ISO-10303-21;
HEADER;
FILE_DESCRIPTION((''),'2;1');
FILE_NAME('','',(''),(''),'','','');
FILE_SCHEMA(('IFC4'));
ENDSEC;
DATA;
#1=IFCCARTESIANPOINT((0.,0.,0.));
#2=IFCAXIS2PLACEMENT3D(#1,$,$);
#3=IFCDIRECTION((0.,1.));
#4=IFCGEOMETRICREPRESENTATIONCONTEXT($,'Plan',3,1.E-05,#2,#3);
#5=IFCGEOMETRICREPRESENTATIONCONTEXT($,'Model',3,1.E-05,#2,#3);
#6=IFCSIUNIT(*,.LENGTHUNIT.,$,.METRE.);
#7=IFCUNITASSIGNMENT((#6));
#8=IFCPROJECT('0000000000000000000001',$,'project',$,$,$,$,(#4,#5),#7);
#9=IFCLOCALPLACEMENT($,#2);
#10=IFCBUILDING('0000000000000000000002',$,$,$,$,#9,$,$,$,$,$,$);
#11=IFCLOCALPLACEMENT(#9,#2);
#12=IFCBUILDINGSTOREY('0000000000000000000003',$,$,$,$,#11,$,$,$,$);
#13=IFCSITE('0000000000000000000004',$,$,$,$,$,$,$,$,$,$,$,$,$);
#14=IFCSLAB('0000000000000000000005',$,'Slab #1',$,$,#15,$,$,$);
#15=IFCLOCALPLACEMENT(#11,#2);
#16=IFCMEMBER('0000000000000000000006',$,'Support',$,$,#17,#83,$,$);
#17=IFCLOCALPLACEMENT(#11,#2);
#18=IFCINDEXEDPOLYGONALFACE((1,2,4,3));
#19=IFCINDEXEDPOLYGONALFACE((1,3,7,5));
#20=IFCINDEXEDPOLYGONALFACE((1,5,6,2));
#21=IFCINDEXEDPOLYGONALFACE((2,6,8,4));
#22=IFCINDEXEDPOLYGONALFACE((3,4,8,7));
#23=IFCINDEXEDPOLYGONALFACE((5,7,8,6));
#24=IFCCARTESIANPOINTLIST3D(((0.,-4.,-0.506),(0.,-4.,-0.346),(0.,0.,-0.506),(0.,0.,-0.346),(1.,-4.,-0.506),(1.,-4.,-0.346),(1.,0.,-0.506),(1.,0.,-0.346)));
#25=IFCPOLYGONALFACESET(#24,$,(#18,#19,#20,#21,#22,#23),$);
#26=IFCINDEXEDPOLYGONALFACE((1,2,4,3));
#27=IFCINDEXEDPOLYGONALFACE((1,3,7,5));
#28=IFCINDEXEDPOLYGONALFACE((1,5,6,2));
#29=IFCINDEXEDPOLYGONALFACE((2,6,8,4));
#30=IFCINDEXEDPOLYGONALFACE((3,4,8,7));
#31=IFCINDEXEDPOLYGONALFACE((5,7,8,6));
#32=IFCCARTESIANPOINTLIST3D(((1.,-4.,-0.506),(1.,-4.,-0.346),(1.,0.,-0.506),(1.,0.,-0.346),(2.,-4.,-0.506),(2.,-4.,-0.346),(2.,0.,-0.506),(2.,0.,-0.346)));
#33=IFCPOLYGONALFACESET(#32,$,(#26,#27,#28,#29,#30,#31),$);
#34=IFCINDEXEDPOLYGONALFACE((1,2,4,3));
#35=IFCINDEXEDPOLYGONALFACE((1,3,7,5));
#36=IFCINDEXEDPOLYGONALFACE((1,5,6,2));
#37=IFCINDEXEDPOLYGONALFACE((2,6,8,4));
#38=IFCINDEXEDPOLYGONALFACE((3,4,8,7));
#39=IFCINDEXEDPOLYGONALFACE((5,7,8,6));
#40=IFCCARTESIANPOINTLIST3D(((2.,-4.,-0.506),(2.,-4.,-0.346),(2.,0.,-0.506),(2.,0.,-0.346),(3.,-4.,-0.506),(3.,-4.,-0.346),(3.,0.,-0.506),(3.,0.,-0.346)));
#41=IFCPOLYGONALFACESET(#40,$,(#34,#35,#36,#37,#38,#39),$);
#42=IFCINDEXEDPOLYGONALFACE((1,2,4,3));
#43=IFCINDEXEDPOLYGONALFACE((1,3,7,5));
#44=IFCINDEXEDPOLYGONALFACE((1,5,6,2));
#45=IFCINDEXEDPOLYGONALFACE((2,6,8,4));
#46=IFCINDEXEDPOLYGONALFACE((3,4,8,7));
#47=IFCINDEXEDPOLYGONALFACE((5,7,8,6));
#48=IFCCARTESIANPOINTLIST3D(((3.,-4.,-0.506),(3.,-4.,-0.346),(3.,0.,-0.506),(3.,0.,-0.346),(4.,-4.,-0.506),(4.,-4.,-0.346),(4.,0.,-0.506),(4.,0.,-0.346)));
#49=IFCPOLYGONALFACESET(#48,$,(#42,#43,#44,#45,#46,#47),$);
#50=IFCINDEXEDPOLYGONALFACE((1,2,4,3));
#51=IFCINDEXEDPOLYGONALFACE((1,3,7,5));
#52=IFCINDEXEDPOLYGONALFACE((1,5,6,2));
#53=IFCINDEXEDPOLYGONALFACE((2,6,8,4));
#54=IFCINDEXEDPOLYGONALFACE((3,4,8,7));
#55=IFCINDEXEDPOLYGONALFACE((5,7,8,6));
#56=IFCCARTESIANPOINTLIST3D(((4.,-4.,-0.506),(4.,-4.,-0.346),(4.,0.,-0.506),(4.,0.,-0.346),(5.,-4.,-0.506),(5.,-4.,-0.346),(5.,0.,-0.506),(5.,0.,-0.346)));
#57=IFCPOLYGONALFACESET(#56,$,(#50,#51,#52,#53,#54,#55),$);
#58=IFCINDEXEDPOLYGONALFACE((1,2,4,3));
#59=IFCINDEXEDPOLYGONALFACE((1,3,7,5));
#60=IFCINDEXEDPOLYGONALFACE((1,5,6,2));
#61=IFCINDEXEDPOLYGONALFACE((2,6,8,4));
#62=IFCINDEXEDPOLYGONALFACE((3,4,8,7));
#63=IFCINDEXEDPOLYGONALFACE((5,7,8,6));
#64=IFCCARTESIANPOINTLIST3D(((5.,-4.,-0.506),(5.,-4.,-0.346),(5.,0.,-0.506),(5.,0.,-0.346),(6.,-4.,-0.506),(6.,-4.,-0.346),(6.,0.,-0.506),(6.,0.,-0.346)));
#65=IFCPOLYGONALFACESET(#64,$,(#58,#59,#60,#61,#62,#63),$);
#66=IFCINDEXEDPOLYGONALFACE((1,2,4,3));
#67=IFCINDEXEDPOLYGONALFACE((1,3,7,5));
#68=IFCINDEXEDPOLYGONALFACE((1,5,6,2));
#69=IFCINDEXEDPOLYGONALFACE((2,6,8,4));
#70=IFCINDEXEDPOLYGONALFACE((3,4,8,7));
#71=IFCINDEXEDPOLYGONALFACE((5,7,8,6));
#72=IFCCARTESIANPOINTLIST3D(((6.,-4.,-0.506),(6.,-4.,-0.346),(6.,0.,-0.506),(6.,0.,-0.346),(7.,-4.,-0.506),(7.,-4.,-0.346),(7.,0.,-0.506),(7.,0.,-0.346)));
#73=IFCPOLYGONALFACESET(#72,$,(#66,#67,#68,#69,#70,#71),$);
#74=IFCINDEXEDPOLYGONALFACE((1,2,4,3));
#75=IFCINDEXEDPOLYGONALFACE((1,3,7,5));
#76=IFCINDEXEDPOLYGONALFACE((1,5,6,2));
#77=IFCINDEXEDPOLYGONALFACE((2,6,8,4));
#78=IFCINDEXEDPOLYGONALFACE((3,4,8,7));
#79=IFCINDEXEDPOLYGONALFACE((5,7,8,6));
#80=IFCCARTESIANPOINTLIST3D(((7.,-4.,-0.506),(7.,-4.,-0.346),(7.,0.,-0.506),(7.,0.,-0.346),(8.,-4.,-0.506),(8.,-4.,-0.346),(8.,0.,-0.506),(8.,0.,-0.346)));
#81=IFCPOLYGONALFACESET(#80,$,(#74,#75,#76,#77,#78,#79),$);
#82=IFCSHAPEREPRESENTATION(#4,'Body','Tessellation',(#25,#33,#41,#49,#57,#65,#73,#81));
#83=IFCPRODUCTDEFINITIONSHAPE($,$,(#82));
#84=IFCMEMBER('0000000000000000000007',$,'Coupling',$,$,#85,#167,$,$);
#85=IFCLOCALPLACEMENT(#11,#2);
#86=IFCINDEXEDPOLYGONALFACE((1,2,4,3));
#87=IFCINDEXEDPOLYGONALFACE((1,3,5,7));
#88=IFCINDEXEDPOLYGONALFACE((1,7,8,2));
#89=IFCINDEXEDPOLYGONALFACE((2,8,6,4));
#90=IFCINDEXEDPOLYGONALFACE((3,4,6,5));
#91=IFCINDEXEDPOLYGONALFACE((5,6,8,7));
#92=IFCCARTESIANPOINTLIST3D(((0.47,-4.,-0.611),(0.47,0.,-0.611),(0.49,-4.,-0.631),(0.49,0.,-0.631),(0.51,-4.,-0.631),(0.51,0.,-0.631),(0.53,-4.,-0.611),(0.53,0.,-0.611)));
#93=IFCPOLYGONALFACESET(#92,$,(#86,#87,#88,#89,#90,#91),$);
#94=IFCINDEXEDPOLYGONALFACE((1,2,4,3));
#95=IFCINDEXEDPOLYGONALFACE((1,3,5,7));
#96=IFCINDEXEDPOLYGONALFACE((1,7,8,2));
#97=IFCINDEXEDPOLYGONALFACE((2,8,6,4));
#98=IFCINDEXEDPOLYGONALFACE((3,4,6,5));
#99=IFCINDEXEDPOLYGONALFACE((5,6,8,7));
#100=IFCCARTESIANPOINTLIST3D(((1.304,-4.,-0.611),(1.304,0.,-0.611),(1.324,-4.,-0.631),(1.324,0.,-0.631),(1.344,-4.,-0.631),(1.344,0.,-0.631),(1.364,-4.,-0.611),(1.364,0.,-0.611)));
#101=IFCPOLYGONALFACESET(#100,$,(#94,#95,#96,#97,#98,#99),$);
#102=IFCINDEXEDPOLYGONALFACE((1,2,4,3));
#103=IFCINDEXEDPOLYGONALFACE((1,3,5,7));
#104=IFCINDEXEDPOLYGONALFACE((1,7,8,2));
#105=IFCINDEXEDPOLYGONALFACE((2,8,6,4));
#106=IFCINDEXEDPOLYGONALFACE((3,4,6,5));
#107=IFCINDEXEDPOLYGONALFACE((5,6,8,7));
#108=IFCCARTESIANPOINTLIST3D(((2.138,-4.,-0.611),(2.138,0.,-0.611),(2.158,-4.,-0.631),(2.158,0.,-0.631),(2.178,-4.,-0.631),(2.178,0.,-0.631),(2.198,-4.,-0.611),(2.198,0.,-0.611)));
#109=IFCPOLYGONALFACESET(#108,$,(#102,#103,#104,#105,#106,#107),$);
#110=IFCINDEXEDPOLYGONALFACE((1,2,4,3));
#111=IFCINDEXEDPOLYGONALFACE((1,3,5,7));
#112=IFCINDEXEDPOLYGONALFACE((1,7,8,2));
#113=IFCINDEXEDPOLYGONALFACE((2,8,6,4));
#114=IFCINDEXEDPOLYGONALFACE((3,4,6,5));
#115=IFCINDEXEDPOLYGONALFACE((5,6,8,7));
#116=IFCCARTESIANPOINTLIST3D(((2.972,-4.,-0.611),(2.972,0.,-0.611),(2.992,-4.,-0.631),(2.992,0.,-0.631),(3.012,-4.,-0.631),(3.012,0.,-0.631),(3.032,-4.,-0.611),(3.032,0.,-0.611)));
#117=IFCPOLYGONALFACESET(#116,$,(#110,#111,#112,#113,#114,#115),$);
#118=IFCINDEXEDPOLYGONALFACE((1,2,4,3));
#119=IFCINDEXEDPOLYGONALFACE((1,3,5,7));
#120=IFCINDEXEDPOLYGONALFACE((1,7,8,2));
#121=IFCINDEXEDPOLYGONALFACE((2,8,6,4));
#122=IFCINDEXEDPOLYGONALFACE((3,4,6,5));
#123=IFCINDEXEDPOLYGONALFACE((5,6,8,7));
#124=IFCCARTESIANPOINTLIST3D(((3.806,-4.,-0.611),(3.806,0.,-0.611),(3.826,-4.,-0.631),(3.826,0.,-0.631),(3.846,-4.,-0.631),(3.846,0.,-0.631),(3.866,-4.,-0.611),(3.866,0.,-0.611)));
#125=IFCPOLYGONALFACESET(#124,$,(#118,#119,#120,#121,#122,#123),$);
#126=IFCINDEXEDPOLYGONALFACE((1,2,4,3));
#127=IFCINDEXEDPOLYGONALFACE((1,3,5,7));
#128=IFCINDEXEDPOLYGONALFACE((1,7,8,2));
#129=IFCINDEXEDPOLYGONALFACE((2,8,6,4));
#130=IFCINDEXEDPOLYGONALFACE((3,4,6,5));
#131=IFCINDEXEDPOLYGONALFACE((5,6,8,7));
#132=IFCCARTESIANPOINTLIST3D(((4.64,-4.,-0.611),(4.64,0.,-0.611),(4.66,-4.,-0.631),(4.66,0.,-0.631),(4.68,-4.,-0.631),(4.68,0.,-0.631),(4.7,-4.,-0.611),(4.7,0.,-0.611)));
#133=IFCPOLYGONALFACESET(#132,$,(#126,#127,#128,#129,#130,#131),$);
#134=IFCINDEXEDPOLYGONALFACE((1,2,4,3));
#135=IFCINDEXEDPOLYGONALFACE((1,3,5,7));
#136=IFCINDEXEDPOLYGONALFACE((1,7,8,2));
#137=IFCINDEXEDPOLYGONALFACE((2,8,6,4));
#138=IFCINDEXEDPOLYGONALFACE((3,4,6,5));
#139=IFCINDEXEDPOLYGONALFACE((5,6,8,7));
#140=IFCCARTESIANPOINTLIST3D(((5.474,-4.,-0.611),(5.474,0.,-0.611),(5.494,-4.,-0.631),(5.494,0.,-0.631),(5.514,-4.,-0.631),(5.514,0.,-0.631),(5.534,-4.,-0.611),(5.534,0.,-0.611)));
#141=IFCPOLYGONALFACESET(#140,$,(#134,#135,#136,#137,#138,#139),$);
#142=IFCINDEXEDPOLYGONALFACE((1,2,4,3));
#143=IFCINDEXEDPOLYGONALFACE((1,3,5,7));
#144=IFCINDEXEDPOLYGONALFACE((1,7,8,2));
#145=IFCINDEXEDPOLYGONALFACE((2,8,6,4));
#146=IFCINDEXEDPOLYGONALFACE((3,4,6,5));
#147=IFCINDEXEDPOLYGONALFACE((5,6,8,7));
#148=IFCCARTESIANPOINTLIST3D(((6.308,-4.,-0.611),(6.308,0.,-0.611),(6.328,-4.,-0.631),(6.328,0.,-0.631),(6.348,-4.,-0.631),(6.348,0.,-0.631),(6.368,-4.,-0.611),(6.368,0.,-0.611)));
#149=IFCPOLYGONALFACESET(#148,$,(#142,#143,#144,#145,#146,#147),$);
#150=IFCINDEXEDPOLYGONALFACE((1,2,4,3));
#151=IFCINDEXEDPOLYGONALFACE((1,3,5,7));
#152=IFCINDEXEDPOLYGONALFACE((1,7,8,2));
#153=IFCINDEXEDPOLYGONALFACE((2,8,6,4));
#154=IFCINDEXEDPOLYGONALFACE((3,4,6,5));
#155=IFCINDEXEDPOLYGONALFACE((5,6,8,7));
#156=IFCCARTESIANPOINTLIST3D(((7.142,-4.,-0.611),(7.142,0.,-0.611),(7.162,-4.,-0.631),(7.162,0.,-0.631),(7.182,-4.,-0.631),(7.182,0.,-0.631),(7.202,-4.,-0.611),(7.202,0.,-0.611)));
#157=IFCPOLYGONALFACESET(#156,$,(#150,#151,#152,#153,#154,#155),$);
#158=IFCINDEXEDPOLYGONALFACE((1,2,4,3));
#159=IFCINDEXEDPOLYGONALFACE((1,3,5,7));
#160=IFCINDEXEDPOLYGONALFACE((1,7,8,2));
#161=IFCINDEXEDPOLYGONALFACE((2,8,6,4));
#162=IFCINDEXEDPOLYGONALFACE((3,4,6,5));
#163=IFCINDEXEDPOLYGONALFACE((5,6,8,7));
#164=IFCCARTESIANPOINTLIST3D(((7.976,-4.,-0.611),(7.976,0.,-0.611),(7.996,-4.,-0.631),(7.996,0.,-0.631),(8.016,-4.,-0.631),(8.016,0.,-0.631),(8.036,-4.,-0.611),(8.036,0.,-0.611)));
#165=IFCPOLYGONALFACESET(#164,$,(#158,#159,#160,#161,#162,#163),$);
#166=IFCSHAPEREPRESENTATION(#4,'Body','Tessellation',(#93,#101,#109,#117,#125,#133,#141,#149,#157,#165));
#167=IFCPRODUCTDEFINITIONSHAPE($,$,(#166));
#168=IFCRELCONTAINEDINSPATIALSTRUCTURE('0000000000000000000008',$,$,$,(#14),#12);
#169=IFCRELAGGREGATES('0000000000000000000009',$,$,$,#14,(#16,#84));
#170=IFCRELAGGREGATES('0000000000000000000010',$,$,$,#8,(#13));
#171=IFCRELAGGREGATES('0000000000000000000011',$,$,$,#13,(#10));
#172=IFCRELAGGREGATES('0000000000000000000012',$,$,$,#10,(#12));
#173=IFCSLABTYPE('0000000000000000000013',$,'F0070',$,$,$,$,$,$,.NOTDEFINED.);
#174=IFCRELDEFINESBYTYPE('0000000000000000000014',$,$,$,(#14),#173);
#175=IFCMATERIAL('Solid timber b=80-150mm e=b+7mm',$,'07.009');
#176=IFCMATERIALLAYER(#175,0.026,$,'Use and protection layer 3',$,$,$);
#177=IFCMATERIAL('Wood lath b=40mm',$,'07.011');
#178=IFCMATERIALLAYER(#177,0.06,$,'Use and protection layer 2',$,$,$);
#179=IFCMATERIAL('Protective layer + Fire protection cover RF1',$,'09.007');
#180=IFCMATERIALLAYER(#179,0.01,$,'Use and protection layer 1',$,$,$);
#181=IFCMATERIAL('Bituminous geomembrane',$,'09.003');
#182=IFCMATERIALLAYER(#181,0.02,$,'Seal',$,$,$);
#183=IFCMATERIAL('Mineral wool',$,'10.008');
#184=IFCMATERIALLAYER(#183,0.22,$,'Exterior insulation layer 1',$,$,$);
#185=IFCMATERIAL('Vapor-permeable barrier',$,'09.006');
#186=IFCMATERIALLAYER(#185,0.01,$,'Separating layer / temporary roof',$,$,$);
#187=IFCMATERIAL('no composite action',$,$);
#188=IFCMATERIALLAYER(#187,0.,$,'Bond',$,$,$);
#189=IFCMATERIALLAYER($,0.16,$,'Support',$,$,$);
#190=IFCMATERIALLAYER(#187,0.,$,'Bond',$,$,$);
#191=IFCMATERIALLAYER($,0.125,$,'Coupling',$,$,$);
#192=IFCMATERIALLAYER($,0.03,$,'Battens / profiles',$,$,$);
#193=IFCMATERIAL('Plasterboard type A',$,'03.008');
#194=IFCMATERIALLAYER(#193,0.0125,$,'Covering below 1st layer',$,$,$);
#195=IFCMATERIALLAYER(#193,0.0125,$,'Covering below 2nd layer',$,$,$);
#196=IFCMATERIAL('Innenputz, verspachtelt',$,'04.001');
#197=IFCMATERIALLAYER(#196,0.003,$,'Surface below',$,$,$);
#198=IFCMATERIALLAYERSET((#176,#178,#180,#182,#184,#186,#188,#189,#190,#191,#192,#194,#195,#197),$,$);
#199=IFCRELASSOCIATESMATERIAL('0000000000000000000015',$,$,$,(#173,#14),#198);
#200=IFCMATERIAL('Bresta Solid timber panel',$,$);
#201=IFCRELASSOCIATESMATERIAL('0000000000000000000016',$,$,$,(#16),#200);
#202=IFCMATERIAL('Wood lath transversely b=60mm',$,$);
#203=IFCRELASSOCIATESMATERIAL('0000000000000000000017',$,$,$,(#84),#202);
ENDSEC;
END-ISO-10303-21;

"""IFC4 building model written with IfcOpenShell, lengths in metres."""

from ifc_helpers import new_model, si_unit, direction, frame, frame_2d, origin, place, context, project, spatial, polyline, rectangle, outline, extrude, material, layer, layer_set, type_object, element, aggregate, save


model = new_model("IFC4")

# Units and contexts
plan_context = context("Plan", 3, precision=1e-05, world=origin(), true_north=direction((0.0, 1.0)))
model_context = context("Model", 3, precision=1e-05, world=origin(), true_north=direction((0.0, 1.0)))
ifc_project = project(units=[si_unit("LENGTHUNIT", "METRE")], contexts=[plan_context, model_context])

# Site, building, storey
site = spatial("IfcSite", under=ifc_project)
building_placement = place(None, origin())
building = spatial("IfcBuilding", under=site, at=building_placement)
storey_placement = place(building_placement, origin())
storey = spatial("IfcBuildingStorey", under=building, at=storey_placement)

# Slab, members
ifc_material_1 = material(Name="Solid timber b=80-150mm e=b+7mm", Category="07.009")
ifc_layer_1 = layer(ifc_material_1, 0.026, Name="Use and protection layer 3")
ifc_material_2 = material(Name="Wood lath b=40mm", Category="07.011")
ifc_layer_2 = layer(ifc_material_2, 0.06, Name="Use and protection layer 2")
ifc_material_3 = material(Name="Protective layer + Fire protection cover RF1", Category="09.007")
ifc_layer_3 = layer(ifc_material_3, 0.01, Name="Use and protection layer 1")
ifc_material_4 = material(Name="Bituminous geomembrane", Category="09.003")
ifc_layer_4 = layer(ifc_material_4, 0.02, Name="Seal")
ifc_material_5 = material(Name="Mineral wool", Category="10.008")
ifc_layer_5 = layer(ifc_material_5, 0.22, Name="Exterior insulation layer 1")
ifc_material_6 = material(Name="Vapor-permeable barrier", Category="09.006")
ifc_layer_6 = layer(ifc_material_6, 0.01, Name="Separating layer / temporary roof")
ifc_material_7 = material(Name="no composite action")
ifc_layer_7 = layer(ifc_material_7, 0.0, Name="Bond")
ifc_layer_8 = layer(None, 0.16, Name="Support")
ifc_layer_9 = layer(ifc_material_7, 0.0, Name="Bond")
ifc_layer_10 = layer(None, 0.125, Name="Coupling")
ifc_layer_11 = layer(None, 0.03, Name="Battens / profiles")
ifc_material_8 = material(Name="Plasterboard type A", Category="03.008")
ifc_layer_12 = layer(ifc_material_8, 0.0125, Name="Covering below 1st layer")
ifc_layer_13 = layer(ifc_material_8, 0.0125, Name="Covering below 2nd layer")
ifc_material_9 = material(Name="Innenputz, verspachtelt", Category="04.001")
ifc_layer_14 = layer(ifc_material_9, 0.003, Name="Surface below")
ifc_layer_set = layer_set([ifc_layer_1, ifc_layer_2, ifc_layer_3, ifc_layer_4, ifc_layer_5, ifc_layer_6, ifc_layer_7, ifc_layer_8, ifc_layer_9, ifc_layer_10, ifc_layer_11, ifc_layer_12, ifc_layer_13, ifc_layer_14])
slab_type = type_object("IfcSlabType", Name="F0070", PredefinedType="NOTDEFINED", material=ifc_layer_set)
slab_placement = place(None, frame((0.0, 0.0, 0.0), z_axis=(0.0, 0.0, -1.0), x_axis=(1.0, 0.0, 0.0)))
slab = element("IfcSlab", 1, at=slab_placement, inside=storey, type_object=slab_type, material=ifc_layer_set, Name="Slab #1")
ifc_material_10 = material(Name="Bresta Solid timber panel")
member_1_placement = place(slab_placement, origin())
member_1 = element("IfcMember", 2, at=member_1_placement, material=ifc_material_10, Name="Support", context=plan_context, shape_type="SweptSolid", body=[
    extrude(rectangle(XDim=1.0, YDim=0.16, at=frame_2d((0.5, 0.08), x_axis=(1.0, 0.0))), frame((0.0, 4.0, 0.346), z_axis=(0.0, -1.0, 0.0), x_axis=(1.0, 0.0, 0.0)), (0.0, 0.0, 1.0), 4.0),
    extrude(rectangle(XDim=1.0, YDim=0.16, at=frame_2d((0.5, 0.08), x_axis=(1.0, 0.0))), frame((1.0, 4.0, 0.346), z_axis=(0.0, -1.0, 0.0), x_axis=(1.0, 0.0, 0.0)), (0.0, 0.0, 1.0), 4.0),
    extrude(rectangle(XDim=1.0, YDim=0.16, at=frame_2d((0.5, 0.08), x_axis=(1.0, 0.0))), frame((2.0, 4.0, 0.346), z_axis=(0.0, -1.0, 0.0), x_axis=(1.0, 0.0, 0.0)), (0.0, 0.0, 1.0), 4.0),
    extrude(rectangle(XDim=1.0, YDim=0.16, at=frame_2d((0.5, 0.08), x_axis=(1.0, 0.0))), frame((3.0, 4.0, 0.346), z_axis=(0.0, -1.0, 0.0), x_axis=(1.0, 0.0, 0.0)), (0.0, 0.0, 1.0), 4.0),
    extrude(rectangle(XDim=1.0, YDim=0.16, at=frame_2d((0.5, 0.08), x_axis=(1.0, 0.0))), frame((4.0, 4.0, 0.346), z_axis=(0.0, -1.0, 0.0), x_axis=(1.0, 0.0, 0.0)), (0.0, 0.0, 1.0), 4.0),
    extrude(rectangle(XDim=1.0, YDim=0.16, at=frame_2d((0.5, 0.08), x_axis=(1.0, 0.0))), frame((5.0, 4.0, 0.346), z_axis=(0.0, -1.0, 0.0), x_axis=(1.0, 0.0, 0.0)), (0.0, 0.0, 1.0), 4.0),
    extrude(rectangle(XDim=1.0, YDim=0.16, at=frame_2d((0.5, 0.08), x_axis=(1.0, 0.0))), frame((6.0, 4.0, 0.346), z_axis=(0.0, -1.0, 0.0), x_axis=(1.0, 0.0, 0.0)), (0.0, 0.0, 1.0), 4.0),
    extrude(rectangle(XDim=1.0, YDim=0.16, at=frame_2d((0.5, 0.08), x_axis=(1.0, 0.0))), frame((7.0, 4.0, 0.346), z_axis=(0.0, -1.0, 0.0), x_axis=(1.0, 0.0, 0.0)), (0.0, 0.0, 1.0), 4.0),
])
ifc_material_11 = material(Name="Wood lath transversely b=60mm")
member_2_placement = place(slab_placement, origin())
member_2 = element("IfcMember", 3, at=member_2_placement, material=ifc_material_11, Name="Coupling", context=plan_context, shape_type="SweptSolid", body=[
    extrude(outline(polyline([(0.0, 0.0), (0.06, 0.0), (0.04, 0.02), (0.02, 0.02), (0.0, 0.0)])), frame((0.47, 4.0, 0.611), z_axis=(0.0, -1.0, 0.0), x_axis=(1.0, 0.0, 0.0)), (0.0, 0.0, 1.0), 4.0),
    extrude(outline(polyline([(0.0, 0.0), (0.06, 0.0), (0.04, 0.02), (0.02, 0.02), (0.0, 0.0)])), frame((1.304, 4.0, 0.611), z_axis=(0.0, -1.0, 0.0), x_axis=(1.0, 0.0, 0.0)), (0.0, 0.0, 1.0), 4.0),
    extrude(outline(polyline([(0.0, 0.0), (0.06, 0.0), (0.04, 0.02), (0.02, 0.02), (0.0, 0.0)])), frame((2.138, 4.0, 0.611), z_axis=(0.0, -1.0, 0.0), x_axis=(1.0, 0.0, 0.0)), (0.0, 0.0, 1.0), 4.0),
    extrude(outline(polyline([(0.0, 0.0), (0.06, 0.0), (0.04, 0.02), (0.02, 0.02), (0.0, 0.0)])), frame((2.972, 4.0, 0.611), z_axis=(0.0, -1.0, 0.0), x_axis=(1.0, 0.0, 0.0)), (0.0, 0.0, 1.0), 4.0),
    extrude(outline(polyline([(0.0, 0.0), (0.06, 0.0), (0.04, 0.02), (0.02, 0.02), (0.0, 0.0)])), frame((3.806, 4.0, 0.611), z_axis=(0.0, -1.0, 0.0), x_axis=(1.0, 0.0, 0.0)), (0.0, 0.0, 1.0), 4.0),
    extrude(outline(polyline([(0.0, 0.0), (0.06, 0.0), (0.04, 0.02), (0.02, 0.02), (0.0, 0.0)])), frame((4.64, 4.0, 0.611), z_axis=(0.0, -1.0, 0.0), x_axis=(1.0, 0.0, 0.0)), (0.0, 0.0, 1.0), 4.0),
    extrude(outline(polyline([(0.0, 0.0), (0.06, 0.0), (0.04, 0.02), (0.02, 0.02), (0.0, 0.0)])), frame((5.474, 4.0, 0.611), z_axis=(0.0, -1.0, 0.0), x_axis=(1.0, 0.0, 0.0)), (0.0, 0.0, 1.0), 4.0),
    extrude(outline(polyline([(0.0, 0.0), (0.06, 0.0), (0.04, 0.02), (0.02, 0.02), (0.0, 0.0)])), frame((6.308, 4.0, 0.611), z_axis=(0.0, -1.0, 0.0), x_axis=(1.0, 0.0, 0.0)), (0.0, 0.0, 1.0), 4.0),
    extrude(outline(polyline([(0.0, 0.0), (0.06, 0.0), (0.04, 0.02), (0.02, 0.02), (0.0, 0.0)])), frame((7.142, 4.0, 0.611), z_axis=(0.0, -1.0, 0.0), x_axis=(1.0, 0.0, 0.0)), (0.0, 0.0, 1.0), 4.0),
    extrude(outline(polyline([(0.0, 0.0), (0.06, 0.0), (0.04, 0.02), (0.02, 0.02), (0.0, 0.0)])), frame((7.976, 4.0, 0.611), z_axis=(0.0, -1.0, 0.0), x_axis=(1.0, 0.0, 0.0)), (0.0, 0.0, 1.0), 4.0),
])
aggregate(slab, [member_1, member_2])

save(model, "model.ifc")
